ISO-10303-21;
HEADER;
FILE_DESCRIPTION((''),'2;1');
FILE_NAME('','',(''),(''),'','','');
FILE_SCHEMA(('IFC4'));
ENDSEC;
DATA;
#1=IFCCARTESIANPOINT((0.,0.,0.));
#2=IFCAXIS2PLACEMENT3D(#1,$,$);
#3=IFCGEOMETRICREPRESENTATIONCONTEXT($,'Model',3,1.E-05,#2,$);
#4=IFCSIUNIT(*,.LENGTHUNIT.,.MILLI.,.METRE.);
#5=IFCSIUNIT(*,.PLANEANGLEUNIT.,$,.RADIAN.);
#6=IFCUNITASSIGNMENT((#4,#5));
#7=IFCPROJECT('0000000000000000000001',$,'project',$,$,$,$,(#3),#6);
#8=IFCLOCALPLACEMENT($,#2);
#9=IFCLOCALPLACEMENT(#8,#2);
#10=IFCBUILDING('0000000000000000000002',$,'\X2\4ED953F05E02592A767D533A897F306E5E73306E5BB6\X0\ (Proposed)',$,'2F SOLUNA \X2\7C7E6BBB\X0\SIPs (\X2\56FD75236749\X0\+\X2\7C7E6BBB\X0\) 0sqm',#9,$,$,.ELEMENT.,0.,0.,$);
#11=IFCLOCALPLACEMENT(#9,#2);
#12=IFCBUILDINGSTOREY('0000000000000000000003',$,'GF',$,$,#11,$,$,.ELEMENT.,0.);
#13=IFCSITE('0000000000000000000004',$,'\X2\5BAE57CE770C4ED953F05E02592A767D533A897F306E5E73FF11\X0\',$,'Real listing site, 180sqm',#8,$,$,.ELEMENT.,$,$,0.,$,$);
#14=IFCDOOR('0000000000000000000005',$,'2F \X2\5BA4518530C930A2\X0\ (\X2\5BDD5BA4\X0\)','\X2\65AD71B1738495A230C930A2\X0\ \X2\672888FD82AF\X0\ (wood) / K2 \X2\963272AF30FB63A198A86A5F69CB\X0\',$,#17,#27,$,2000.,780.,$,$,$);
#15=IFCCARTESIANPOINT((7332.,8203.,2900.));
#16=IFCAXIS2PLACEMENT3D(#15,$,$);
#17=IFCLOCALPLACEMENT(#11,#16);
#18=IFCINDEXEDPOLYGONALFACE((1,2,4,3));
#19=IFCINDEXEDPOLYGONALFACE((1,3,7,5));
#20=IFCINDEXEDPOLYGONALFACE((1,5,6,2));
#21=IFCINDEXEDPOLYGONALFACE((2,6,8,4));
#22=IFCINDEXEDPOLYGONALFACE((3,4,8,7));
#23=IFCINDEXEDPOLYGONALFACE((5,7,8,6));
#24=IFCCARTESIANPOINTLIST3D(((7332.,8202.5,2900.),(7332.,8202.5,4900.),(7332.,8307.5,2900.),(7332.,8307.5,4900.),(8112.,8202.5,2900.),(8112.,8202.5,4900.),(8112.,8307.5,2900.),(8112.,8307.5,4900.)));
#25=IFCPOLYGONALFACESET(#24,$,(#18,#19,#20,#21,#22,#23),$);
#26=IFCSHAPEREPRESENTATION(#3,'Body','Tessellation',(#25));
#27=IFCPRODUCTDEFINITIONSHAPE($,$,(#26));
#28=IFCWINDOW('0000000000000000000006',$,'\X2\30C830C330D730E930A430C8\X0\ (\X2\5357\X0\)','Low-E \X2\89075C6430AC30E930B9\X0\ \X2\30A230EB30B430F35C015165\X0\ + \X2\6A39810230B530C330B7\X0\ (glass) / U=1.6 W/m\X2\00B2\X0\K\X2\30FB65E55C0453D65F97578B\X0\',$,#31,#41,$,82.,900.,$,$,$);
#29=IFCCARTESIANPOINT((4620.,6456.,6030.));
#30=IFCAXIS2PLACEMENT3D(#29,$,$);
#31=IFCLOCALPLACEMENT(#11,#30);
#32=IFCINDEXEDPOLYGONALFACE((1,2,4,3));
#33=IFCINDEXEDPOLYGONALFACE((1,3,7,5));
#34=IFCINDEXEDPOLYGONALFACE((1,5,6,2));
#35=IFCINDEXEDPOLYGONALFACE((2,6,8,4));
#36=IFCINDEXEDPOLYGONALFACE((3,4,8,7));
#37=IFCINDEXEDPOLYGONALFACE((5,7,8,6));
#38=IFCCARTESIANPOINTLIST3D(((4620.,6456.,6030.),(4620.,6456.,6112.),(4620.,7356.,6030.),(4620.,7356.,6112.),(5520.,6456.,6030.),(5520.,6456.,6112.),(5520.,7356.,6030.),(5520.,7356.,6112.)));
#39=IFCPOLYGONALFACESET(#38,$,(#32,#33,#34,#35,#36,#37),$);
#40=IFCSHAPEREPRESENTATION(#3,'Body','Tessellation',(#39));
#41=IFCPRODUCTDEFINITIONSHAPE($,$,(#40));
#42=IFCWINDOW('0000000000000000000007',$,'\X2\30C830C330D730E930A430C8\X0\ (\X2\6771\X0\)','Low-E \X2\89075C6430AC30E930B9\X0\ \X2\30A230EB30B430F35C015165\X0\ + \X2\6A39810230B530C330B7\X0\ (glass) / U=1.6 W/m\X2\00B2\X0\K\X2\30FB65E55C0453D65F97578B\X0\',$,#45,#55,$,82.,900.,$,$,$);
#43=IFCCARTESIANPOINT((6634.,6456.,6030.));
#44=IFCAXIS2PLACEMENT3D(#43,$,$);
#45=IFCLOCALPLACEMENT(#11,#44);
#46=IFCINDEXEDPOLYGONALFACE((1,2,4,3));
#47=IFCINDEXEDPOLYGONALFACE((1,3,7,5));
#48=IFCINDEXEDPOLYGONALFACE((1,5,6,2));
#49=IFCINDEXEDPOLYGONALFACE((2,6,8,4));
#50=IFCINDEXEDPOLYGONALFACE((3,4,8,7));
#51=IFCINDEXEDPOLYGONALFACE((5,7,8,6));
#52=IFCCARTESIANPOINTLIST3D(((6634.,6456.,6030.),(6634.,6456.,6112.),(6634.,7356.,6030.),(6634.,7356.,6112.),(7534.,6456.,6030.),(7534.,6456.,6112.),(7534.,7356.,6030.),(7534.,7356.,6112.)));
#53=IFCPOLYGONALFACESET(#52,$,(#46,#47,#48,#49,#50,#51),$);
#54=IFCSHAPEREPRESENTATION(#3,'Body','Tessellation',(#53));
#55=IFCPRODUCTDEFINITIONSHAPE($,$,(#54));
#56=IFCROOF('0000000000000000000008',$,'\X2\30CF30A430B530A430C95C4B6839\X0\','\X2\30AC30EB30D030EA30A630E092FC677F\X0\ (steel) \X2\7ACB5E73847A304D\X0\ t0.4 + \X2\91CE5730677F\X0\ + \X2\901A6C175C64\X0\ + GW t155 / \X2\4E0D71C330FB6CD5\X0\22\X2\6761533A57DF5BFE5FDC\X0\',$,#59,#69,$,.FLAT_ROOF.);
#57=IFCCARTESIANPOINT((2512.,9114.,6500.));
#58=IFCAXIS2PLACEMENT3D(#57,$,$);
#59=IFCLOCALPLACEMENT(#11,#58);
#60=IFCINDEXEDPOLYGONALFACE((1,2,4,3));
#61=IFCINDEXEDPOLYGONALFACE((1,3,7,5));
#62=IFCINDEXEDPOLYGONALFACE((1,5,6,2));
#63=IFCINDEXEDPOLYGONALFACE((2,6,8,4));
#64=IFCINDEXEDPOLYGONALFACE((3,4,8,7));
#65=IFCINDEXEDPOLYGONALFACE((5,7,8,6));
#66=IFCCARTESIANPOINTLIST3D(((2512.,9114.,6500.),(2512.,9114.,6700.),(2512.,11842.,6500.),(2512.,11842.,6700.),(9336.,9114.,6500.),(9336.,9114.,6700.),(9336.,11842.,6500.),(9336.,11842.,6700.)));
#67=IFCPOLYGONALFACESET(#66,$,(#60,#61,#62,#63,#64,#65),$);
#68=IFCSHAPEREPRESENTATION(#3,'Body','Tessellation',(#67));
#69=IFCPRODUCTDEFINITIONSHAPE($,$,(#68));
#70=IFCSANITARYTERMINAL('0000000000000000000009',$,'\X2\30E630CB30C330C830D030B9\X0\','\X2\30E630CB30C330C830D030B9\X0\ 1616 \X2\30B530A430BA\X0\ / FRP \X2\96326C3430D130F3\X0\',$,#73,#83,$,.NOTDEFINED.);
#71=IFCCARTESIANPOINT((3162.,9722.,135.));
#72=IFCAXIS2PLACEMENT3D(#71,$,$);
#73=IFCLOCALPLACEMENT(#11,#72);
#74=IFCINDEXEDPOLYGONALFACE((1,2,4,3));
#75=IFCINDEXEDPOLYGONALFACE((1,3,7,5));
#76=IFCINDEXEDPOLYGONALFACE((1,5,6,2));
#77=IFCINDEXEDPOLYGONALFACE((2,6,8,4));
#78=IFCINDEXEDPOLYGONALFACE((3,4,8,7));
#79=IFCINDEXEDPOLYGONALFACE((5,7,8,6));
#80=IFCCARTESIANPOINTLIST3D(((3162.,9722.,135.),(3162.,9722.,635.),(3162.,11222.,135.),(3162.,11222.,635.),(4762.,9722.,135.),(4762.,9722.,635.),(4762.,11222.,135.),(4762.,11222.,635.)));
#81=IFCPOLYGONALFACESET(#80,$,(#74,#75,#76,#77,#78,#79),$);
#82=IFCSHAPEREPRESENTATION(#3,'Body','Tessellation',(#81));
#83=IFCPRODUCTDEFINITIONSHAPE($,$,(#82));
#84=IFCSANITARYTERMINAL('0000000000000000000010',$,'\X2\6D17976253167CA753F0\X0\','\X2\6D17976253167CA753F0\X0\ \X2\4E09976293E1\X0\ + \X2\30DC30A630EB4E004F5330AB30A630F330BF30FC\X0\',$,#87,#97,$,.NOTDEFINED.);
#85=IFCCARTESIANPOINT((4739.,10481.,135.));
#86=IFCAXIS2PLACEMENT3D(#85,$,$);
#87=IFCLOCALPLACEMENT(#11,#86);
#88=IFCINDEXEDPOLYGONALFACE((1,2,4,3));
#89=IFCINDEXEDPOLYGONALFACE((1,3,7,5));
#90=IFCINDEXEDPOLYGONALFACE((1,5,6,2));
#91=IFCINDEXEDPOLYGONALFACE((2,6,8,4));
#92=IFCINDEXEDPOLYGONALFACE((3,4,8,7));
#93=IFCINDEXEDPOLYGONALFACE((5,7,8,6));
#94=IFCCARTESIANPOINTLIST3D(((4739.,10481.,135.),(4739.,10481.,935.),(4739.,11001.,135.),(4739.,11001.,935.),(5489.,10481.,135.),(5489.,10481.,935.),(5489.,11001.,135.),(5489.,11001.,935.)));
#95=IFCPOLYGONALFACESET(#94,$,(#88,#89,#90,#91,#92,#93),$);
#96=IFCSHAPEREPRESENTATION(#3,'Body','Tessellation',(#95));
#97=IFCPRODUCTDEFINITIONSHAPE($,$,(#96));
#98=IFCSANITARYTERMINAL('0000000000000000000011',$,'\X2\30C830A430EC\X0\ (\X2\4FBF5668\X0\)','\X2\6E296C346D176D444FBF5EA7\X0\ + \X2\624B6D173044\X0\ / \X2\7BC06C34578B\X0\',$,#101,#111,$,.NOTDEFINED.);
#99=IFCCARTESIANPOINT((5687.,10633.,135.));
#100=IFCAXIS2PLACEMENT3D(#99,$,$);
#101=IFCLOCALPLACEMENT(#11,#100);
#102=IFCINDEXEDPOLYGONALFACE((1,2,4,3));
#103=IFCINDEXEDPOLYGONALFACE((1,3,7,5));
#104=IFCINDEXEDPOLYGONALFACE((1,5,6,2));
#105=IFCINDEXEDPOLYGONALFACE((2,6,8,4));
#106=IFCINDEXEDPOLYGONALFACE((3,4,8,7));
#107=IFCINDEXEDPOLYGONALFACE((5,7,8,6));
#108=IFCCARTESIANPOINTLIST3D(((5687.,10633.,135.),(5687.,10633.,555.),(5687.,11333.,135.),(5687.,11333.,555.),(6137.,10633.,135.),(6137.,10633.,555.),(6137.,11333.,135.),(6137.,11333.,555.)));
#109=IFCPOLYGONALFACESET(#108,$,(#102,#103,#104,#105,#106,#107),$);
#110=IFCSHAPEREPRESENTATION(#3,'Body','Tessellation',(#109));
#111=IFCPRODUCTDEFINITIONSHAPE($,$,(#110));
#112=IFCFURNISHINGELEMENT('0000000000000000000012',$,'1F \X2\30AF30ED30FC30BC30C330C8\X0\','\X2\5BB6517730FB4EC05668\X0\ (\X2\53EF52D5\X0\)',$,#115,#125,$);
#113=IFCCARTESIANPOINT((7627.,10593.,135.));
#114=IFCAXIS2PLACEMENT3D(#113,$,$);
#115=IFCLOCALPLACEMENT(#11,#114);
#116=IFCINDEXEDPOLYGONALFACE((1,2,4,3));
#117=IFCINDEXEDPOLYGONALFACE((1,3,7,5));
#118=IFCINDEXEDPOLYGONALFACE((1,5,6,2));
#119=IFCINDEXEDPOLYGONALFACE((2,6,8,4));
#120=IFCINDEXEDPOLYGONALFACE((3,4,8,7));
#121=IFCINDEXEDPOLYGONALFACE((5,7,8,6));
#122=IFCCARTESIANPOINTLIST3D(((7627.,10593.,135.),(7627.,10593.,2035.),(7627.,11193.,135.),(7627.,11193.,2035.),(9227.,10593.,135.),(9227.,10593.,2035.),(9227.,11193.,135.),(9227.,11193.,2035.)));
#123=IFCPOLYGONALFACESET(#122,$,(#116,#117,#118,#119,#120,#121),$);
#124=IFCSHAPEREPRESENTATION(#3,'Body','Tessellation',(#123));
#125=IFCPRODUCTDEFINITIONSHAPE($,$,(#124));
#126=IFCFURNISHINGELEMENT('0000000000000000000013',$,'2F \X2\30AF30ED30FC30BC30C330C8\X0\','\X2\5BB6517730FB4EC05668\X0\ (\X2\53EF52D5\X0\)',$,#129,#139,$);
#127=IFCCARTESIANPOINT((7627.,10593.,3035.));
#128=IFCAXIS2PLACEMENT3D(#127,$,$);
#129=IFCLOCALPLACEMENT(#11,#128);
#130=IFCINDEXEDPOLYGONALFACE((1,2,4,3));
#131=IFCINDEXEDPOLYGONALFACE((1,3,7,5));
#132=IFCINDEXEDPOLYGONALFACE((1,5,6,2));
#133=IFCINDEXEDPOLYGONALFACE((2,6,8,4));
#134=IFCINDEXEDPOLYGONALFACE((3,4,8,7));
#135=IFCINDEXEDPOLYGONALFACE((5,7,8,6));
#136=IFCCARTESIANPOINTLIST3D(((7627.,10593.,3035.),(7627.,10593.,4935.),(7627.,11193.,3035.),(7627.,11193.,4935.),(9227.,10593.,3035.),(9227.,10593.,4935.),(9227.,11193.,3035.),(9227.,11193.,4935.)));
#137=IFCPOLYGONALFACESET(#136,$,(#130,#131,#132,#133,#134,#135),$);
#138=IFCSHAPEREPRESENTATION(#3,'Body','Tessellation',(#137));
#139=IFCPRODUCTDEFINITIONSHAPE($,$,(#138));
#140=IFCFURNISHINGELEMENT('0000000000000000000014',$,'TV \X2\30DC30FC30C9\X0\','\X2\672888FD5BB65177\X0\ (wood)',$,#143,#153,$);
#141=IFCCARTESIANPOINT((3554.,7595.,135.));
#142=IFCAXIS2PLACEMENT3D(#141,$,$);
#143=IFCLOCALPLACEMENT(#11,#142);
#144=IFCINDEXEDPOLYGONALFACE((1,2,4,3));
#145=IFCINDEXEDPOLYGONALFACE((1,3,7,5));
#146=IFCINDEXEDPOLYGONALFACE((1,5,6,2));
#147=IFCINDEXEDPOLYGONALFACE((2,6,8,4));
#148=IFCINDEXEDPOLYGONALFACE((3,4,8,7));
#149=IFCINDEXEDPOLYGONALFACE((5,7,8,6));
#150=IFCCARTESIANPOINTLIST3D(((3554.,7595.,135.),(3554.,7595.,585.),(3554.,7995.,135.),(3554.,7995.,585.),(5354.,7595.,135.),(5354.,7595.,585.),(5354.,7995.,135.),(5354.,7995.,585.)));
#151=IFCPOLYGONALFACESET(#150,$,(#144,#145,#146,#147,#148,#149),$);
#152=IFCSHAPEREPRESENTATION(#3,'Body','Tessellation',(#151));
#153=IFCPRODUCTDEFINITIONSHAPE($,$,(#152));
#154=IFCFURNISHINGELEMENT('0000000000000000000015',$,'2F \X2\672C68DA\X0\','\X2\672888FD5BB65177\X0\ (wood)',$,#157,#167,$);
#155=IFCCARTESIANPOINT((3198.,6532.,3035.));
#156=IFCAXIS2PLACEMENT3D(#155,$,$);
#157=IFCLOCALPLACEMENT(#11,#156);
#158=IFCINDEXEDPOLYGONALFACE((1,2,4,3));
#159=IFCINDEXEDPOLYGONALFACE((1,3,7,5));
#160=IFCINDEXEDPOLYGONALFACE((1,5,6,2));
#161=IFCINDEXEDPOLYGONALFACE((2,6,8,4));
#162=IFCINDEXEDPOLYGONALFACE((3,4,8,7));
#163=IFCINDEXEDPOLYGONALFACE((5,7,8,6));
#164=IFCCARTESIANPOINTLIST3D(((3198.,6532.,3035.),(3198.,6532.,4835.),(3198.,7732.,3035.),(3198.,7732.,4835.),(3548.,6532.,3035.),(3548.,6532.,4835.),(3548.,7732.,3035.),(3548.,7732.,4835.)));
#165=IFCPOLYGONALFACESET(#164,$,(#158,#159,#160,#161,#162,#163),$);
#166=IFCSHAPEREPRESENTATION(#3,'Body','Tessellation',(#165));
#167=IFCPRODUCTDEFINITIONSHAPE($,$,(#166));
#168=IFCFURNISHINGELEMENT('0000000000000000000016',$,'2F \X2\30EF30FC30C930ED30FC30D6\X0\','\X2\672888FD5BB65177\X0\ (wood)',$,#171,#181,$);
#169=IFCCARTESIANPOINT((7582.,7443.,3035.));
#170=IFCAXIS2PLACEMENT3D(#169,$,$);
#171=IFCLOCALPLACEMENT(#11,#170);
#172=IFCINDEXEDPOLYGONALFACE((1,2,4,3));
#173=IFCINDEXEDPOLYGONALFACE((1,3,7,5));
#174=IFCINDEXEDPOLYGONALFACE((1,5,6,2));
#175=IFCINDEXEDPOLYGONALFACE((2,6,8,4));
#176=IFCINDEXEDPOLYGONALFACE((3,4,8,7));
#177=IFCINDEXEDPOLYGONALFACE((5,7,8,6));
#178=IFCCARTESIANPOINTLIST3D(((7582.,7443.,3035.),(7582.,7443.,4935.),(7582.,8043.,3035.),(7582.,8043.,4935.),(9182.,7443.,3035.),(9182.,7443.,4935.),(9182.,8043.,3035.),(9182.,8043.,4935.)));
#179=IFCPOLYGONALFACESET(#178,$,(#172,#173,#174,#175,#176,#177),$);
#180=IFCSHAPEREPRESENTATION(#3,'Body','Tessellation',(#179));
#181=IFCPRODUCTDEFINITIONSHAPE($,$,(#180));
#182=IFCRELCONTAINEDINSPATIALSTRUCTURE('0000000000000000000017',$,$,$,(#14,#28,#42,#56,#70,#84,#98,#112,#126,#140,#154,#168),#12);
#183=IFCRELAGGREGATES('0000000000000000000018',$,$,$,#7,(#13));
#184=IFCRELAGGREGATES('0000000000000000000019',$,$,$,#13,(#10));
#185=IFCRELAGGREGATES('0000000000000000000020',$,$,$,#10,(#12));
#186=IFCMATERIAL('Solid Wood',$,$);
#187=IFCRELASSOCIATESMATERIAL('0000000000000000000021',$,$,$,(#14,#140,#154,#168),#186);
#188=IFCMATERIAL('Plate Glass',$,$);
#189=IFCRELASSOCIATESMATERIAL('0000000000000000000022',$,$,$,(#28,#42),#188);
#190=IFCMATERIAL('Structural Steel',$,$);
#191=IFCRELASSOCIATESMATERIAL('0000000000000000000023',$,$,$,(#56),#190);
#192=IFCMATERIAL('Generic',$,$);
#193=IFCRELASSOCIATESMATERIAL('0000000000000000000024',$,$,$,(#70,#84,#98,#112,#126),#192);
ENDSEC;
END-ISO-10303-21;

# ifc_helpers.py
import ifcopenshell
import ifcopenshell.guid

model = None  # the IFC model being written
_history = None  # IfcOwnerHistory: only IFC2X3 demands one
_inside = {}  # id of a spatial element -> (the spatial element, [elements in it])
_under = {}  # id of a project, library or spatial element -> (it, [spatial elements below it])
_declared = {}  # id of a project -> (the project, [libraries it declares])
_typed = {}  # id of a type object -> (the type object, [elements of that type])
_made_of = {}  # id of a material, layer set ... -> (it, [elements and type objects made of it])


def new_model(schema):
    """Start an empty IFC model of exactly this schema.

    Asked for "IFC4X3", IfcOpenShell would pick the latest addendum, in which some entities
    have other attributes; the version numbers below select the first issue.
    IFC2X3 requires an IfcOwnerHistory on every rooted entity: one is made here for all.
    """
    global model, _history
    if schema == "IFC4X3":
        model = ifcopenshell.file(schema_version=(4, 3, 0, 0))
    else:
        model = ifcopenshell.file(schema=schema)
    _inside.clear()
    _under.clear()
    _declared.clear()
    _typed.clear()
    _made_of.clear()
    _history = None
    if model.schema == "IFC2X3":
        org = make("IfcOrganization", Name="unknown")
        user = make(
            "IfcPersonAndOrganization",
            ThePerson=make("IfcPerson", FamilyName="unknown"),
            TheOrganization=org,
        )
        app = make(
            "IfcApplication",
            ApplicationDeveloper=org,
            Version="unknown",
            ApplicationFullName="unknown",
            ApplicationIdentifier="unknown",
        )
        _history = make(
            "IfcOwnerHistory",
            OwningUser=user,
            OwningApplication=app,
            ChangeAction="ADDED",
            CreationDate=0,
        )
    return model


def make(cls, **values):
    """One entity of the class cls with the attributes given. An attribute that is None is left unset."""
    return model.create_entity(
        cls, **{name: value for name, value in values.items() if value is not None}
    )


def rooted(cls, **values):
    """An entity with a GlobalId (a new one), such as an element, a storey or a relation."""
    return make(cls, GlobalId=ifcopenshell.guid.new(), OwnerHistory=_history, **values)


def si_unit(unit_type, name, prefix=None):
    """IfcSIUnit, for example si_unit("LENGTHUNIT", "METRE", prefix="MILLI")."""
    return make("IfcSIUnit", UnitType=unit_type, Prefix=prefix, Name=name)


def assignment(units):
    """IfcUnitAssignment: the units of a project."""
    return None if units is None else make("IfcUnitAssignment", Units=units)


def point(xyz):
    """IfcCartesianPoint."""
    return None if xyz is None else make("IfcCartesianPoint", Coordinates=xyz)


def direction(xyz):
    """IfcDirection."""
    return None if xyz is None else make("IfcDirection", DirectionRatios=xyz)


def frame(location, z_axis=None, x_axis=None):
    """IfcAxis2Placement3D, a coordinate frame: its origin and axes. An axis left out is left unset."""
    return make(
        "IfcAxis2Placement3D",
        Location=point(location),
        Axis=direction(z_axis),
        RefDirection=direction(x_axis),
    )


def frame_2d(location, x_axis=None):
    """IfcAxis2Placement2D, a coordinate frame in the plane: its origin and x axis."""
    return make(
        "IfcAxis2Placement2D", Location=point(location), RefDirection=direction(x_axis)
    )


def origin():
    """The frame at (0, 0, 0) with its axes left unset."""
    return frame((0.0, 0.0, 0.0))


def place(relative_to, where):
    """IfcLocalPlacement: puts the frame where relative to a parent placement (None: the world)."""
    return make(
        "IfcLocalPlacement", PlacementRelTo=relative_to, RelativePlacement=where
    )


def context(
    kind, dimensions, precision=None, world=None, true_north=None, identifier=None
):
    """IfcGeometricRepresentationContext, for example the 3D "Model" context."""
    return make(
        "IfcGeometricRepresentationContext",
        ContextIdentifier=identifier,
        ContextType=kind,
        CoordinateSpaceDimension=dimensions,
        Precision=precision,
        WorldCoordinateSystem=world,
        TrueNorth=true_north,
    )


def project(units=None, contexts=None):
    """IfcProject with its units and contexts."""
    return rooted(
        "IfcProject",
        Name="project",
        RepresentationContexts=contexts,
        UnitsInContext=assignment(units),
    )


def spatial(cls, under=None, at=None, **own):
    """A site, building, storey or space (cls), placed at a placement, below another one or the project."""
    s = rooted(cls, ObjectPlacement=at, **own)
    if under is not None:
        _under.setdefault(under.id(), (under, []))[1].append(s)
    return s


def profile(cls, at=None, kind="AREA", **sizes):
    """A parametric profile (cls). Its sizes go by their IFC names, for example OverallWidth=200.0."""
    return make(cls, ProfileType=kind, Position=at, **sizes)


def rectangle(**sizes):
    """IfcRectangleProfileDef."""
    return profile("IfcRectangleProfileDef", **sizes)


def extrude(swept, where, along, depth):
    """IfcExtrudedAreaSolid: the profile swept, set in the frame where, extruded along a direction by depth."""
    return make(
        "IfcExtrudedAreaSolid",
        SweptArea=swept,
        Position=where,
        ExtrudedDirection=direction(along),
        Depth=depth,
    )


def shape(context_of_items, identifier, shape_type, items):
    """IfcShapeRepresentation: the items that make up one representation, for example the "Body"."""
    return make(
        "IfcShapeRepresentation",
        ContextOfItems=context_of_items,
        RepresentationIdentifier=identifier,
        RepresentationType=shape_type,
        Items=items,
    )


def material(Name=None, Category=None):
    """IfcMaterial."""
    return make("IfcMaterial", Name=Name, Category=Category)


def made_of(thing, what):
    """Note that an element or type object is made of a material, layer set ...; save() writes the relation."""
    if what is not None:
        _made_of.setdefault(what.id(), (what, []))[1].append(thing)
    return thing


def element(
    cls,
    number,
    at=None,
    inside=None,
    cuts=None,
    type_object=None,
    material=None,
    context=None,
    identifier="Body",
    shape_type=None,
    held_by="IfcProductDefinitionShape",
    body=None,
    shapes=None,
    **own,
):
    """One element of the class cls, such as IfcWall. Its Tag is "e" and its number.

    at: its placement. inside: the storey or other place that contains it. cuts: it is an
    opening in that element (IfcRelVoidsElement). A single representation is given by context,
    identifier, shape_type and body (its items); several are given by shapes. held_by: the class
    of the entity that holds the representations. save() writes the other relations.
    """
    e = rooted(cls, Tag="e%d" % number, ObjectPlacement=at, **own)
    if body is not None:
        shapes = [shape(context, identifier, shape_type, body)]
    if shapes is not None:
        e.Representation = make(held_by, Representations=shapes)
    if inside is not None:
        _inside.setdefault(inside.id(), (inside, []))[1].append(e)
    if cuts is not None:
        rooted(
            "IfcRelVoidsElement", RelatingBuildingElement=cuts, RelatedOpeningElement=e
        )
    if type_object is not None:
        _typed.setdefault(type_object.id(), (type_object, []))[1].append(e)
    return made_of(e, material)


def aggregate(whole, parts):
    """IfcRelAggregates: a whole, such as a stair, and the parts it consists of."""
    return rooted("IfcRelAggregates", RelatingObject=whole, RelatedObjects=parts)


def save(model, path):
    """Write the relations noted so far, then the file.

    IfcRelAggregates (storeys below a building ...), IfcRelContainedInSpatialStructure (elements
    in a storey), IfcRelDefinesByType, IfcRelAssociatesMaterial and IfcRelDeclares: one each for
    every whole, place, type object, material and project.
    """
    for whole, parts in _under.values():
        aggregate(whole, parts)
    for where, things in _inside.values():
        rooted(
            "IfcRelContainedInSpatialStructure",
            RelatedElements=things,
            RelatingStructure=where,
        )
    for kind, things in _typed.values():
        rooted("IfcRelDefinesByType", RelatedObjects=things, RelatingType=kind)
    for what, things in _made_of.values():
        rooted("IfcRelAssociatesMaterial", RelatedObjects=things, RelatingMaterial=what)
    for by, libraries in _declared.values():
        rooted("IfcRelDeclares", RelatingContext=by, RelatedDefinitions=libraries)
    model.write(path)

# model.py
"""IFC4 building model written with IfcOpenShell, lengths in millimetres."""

from ifc_helpers import new_model, si_unit, frame, frame_2d, origin, place, context, project, spatial, rectangle, extrude, material, element, save


model = new_model("IFC4")

# Units and contexts
model_context = context("Model", 3, precision=1e-05, world=origin())
ifc_project = project(units=[si_unit("LENGTHUNIT", "METRE", prefix="MILLI"), si_unit("PLANEANGLEUNIT", "RADIAN")], contexts=[model_context])

# Site, building, storey
site_placement = place(None, origin())
site = spatial("IfcSite", under=ifc_project, at=site_placement, Name="宮城県仙台市太白区西の平１", ObjectType="Real listing site, 180sqm", CompositionType="ELEMENT", RefElevation=0.0)
building_placement = place(site_placement, origin())
building = spatial("IfcBuilding", under=site, at=building_placement, Name="仙台市太白区西の平の家 (Proposed)", ObjectType="2F SOLUNA 籾殻SIPs (国産杉+籾殻) 0sqm", CompositionType="ELEMENT", ElevationOfRefHeight=0.0, ElevationOfTerrain=0.0)
storey_placement = place(building_placement, origin())
storey = spatial("IfcBuildingStorey", under=building, at=storey_placement, Name="GF", CompositionType="ELEMENT", Elevation=0.0)

# Shared definitions
ifc_material_1 = material(Name="Solid Wood")
ifc_material_2 = material(Name="Plate Glass")

# Door
door_1_placement = place(storey_placement, frame((7332.0, 8203.0, 2900.0)))
element("IfcDoor", 1, at=door_1_placement, inside=storey, material=ifc_material_1, Name="2F 室内ドア (寝室)", Description="断熱玄関ドア 木製芯 (wood) / K2 防犯・採風機構", OverallHeight=2000.0, OverallWidth=780.0, context=model_context, shape_type="SweptSolid", body=[
    extrude(rectangle(XDim=780.0, YDim=105.0, at=frame_2d((390.0, 52.0))), frame((7332.0, 8203.0, 2900.0)), (0.0, 0.0, 1.0), 2000.0),
])

# Windows
window_1_placement = place(storey_placement, frame((4620.0, 6456.0, 6030.0)))
element("IfcWindow", 2, at=window_1_placement, inside=storey, material=ifc_material_2, Name="トップライト (南)", Description="Low-E 複層ガラス アルゴン封入 + 樹脂サッシ (glass) / U=1.6 W/m²K・日射取得型", OverallHeight=82.0, OverallWidth=900.0, context=model_context, shape_type="SweptSolid", body=[
    extrude(rectangle(XDim=900.0, YDim=900.0, at=frame_2d((450.0, 450.0))), frame((4620.0, 6456.0, 6030.0)), (0.0, 0.0, 1.0), 82.0),
])
window_2_placement = place(storey_placement, frame((6634.0, 6456.0, 6030.0)))
element("IfcWindow", 3, at=window_2_placement, inside=storey, material=ifc_material_2, Name="トップライト (東)", Description="Low-E 複層ガラス アルゴン封入 + 樹脂サッシ (glass) / U=1.6 W/m²K・日射取得型", OverallHeight=82.0, OverallWidth=900.0, context=model_context, shape_type="SweptSolid", body=[
    extrude(rectangle(XDim=900.0, YDim=900.0, at=frame_2d((450.0, 450.0))), frame((6634.0, 6456.0, 6030.0)), (0.0, 0.0, 1.0), 82.0),
])

# Roof
ifc_material_3 = material(Name="Structural Steel")
roof_placement = place(storey_placement, frame((2512.0, 9114.0, 6500.0)))
element("IfcRoof", 4, at=roof_placement, inside=storey, material=ifc_material_3, Name="ハイサイド屋根", Description="ガルバリウム鋼板 (steel) 立平葺き t0.4 + 野地板 + 通気層 + GW t155 / 不燃・法22条区域対応", PredefinedType="FLAT_ROOF", context=model_context, shape_type="SweptSolid", body=[
    extrude(rectangle(XDim=6824.0, YDim=2728.0, at=frame_2d((3412.0, 1364.0))), frame((2512.0, 9114.0, 6500.0)), (0.0, 0.0, 1.0), 200.0),
])

# Sanitary terminals
ifc_material_4 = material(Name="Generic")
sanitary_terminal_1_placement = place(storey_placement, frame((3162.0, 9722.0, 135.0)))
element("IfcSanitaryTerminal", 5, at=sanitary_terminal_1_placement, inside=storey, material=ifc_material_4, Name="ユニットバス", Description="ユニットバス 1616 サイズ / FRP 防水パン", PredefinedType="NOTDEFINED", context=model_context, shape_type="SweptSolid", body=[
    extrude(rectangle(XDim=1600.0, YDim=1500.0, at=frame_2d((800.0, 750.0))), frame((3162.0, 9722.0, 135.0)), (0.0, 0.0, 1.0), 500.0),
])
sanitary_terminal_2_placement = place(storey_placement, frame((4739.0, 10481.0, 135.0)))
element("IfcSanitaryTerminal", 6, at=sanitary_terminal_2_placement, inside=storey, material=ifc_material_4, Name="洗面化粧台", Description="洗面化粧台 三面鏡 + ボウル一体カウンター", PredefinedType="NOTDEFINED", context=model_context, shape_type="SweptSolid", body=[
    extrude(rectangle(XDim=750.0, YDim=520.0, at=frame_2d((375.0, 260.0))), frame((4739.0, 10481.0, 135.0)), (0.0, 0.0, 1.0), 800.0),
])
sanitary_terminal_3_placement = place(storey_placement, frame((5687.0, 10633.0, 135.0)))
element("IfcSanitaryTerminal", 7, at=sanitary_terminal_3_placement, inside=storey, material=ifc_material_4, Name="トイレ (便器)", Description="温水洗浄便座 + 手洗い / 節水型", PredefinedType="NOTDEFINED", context=model_context, shape_type="SweptSolid", body=[
    extrude(rectangle(XDim=450.0, YDim=700.0, at=frame_2d((225.0, 350.0))), frame((5687.0, 10633.0, 135.0)), (0.0, 0.0, 1.0), 420.0),
])

# Furnishing elements
furnishing_1_placement = place(storey_placement, frame((7627.0, 10593.0, 135.0)))
element("IfcFurnishingElement", 8, at=furnishing_1_placement, inside=storey, material=ifc_material_4, Name="1F クローゼット", Description="家具・什器 (可動)", context=model_context, shape_type="SweptSolid", body=[
    extrude(rectangle(XDim=1600.0, YDim=600.0, at=frame_2d((800.0, 300.0))), frame((7627.0, 10593.0, 135.0)), (0.0, 0.0, 1.0), 1900.0),
])
furnishing_2_placement = place(storey_placement, frame((7627.0, 10593.0, 3035.0)))
element("IfcFurnishingElement", 9, at=furnishing_2_placement, inside=storey, material=ifc_material_4, Name="2F クローゼット", Description="家具・什器 (可動)", context=model_context, shape_type="SweptSolid", body=[
    extrude(rectangle(XDim=1600.0, YDim=600.0, at=frame_2d((800.0, 300.0))), frame((7627.0, 10593.0, 3035.0)), (0.0, 0.0, 1.0), 1900.0),
])
furnishing_3_placement = place(storey_placement, frame((3554.0, 7595.0, 135.0)))
element("IfcFurnishingElement", 10, at=furnishing_3_placement, inside=storey, material=ifc_material_1, Name="TV ボード", Description="木製家具 (wood)", context=model_context, shape_type="SweptSolid", body=[
    extrude(rectangle(XDim=1800.0, YDim=400.0, at=frame_2d((900.0, 200.0))), frame((3554.0, 7595.0, 135.0)), (0.0, 0.0, 1.0), 450.0),
])
furnishing_4_placement = place(storey_placement, frame((3198.0, 6532.0, 3035.0)))
element("IfcFurnishingElement", 11, at=furnishing_4_placement, inside=storey, material=ifc_material_1, Name="2F 本棚", Description="木製家具 (wood)", context=model_context, shape_type="SweptSolid", body=[
    extrude(rectangle(XDim=350.0, YDim=1200.0, at=frame_2d((175.0, 600.0))), frame((3198.0, 6532.0, 3035.0)), (0.0, 0.0, 1.0), 1800.0),
])
furnishing_5_placement = place(storey_placement, frame((7582.0, 7443.0, 3035.0)))
element("IfcFurnishingElement", 12, at=furnishing_5_placement, inside=storey, material=ifc_material_1, Name="2F ワードローブ", Description="木製家具 (wood)", context=model_context, shape_type="SweptSolid", body=[
    extrude(rectangle(XDim=1600.0, YDim=600.0, at=frame_2d((800.0, 300.0))), frame((7582.0, 7443.0, 3035.0)), (0.0, 0.0, 1.0), 1900.0),
])

save(model, "model.ifc")
